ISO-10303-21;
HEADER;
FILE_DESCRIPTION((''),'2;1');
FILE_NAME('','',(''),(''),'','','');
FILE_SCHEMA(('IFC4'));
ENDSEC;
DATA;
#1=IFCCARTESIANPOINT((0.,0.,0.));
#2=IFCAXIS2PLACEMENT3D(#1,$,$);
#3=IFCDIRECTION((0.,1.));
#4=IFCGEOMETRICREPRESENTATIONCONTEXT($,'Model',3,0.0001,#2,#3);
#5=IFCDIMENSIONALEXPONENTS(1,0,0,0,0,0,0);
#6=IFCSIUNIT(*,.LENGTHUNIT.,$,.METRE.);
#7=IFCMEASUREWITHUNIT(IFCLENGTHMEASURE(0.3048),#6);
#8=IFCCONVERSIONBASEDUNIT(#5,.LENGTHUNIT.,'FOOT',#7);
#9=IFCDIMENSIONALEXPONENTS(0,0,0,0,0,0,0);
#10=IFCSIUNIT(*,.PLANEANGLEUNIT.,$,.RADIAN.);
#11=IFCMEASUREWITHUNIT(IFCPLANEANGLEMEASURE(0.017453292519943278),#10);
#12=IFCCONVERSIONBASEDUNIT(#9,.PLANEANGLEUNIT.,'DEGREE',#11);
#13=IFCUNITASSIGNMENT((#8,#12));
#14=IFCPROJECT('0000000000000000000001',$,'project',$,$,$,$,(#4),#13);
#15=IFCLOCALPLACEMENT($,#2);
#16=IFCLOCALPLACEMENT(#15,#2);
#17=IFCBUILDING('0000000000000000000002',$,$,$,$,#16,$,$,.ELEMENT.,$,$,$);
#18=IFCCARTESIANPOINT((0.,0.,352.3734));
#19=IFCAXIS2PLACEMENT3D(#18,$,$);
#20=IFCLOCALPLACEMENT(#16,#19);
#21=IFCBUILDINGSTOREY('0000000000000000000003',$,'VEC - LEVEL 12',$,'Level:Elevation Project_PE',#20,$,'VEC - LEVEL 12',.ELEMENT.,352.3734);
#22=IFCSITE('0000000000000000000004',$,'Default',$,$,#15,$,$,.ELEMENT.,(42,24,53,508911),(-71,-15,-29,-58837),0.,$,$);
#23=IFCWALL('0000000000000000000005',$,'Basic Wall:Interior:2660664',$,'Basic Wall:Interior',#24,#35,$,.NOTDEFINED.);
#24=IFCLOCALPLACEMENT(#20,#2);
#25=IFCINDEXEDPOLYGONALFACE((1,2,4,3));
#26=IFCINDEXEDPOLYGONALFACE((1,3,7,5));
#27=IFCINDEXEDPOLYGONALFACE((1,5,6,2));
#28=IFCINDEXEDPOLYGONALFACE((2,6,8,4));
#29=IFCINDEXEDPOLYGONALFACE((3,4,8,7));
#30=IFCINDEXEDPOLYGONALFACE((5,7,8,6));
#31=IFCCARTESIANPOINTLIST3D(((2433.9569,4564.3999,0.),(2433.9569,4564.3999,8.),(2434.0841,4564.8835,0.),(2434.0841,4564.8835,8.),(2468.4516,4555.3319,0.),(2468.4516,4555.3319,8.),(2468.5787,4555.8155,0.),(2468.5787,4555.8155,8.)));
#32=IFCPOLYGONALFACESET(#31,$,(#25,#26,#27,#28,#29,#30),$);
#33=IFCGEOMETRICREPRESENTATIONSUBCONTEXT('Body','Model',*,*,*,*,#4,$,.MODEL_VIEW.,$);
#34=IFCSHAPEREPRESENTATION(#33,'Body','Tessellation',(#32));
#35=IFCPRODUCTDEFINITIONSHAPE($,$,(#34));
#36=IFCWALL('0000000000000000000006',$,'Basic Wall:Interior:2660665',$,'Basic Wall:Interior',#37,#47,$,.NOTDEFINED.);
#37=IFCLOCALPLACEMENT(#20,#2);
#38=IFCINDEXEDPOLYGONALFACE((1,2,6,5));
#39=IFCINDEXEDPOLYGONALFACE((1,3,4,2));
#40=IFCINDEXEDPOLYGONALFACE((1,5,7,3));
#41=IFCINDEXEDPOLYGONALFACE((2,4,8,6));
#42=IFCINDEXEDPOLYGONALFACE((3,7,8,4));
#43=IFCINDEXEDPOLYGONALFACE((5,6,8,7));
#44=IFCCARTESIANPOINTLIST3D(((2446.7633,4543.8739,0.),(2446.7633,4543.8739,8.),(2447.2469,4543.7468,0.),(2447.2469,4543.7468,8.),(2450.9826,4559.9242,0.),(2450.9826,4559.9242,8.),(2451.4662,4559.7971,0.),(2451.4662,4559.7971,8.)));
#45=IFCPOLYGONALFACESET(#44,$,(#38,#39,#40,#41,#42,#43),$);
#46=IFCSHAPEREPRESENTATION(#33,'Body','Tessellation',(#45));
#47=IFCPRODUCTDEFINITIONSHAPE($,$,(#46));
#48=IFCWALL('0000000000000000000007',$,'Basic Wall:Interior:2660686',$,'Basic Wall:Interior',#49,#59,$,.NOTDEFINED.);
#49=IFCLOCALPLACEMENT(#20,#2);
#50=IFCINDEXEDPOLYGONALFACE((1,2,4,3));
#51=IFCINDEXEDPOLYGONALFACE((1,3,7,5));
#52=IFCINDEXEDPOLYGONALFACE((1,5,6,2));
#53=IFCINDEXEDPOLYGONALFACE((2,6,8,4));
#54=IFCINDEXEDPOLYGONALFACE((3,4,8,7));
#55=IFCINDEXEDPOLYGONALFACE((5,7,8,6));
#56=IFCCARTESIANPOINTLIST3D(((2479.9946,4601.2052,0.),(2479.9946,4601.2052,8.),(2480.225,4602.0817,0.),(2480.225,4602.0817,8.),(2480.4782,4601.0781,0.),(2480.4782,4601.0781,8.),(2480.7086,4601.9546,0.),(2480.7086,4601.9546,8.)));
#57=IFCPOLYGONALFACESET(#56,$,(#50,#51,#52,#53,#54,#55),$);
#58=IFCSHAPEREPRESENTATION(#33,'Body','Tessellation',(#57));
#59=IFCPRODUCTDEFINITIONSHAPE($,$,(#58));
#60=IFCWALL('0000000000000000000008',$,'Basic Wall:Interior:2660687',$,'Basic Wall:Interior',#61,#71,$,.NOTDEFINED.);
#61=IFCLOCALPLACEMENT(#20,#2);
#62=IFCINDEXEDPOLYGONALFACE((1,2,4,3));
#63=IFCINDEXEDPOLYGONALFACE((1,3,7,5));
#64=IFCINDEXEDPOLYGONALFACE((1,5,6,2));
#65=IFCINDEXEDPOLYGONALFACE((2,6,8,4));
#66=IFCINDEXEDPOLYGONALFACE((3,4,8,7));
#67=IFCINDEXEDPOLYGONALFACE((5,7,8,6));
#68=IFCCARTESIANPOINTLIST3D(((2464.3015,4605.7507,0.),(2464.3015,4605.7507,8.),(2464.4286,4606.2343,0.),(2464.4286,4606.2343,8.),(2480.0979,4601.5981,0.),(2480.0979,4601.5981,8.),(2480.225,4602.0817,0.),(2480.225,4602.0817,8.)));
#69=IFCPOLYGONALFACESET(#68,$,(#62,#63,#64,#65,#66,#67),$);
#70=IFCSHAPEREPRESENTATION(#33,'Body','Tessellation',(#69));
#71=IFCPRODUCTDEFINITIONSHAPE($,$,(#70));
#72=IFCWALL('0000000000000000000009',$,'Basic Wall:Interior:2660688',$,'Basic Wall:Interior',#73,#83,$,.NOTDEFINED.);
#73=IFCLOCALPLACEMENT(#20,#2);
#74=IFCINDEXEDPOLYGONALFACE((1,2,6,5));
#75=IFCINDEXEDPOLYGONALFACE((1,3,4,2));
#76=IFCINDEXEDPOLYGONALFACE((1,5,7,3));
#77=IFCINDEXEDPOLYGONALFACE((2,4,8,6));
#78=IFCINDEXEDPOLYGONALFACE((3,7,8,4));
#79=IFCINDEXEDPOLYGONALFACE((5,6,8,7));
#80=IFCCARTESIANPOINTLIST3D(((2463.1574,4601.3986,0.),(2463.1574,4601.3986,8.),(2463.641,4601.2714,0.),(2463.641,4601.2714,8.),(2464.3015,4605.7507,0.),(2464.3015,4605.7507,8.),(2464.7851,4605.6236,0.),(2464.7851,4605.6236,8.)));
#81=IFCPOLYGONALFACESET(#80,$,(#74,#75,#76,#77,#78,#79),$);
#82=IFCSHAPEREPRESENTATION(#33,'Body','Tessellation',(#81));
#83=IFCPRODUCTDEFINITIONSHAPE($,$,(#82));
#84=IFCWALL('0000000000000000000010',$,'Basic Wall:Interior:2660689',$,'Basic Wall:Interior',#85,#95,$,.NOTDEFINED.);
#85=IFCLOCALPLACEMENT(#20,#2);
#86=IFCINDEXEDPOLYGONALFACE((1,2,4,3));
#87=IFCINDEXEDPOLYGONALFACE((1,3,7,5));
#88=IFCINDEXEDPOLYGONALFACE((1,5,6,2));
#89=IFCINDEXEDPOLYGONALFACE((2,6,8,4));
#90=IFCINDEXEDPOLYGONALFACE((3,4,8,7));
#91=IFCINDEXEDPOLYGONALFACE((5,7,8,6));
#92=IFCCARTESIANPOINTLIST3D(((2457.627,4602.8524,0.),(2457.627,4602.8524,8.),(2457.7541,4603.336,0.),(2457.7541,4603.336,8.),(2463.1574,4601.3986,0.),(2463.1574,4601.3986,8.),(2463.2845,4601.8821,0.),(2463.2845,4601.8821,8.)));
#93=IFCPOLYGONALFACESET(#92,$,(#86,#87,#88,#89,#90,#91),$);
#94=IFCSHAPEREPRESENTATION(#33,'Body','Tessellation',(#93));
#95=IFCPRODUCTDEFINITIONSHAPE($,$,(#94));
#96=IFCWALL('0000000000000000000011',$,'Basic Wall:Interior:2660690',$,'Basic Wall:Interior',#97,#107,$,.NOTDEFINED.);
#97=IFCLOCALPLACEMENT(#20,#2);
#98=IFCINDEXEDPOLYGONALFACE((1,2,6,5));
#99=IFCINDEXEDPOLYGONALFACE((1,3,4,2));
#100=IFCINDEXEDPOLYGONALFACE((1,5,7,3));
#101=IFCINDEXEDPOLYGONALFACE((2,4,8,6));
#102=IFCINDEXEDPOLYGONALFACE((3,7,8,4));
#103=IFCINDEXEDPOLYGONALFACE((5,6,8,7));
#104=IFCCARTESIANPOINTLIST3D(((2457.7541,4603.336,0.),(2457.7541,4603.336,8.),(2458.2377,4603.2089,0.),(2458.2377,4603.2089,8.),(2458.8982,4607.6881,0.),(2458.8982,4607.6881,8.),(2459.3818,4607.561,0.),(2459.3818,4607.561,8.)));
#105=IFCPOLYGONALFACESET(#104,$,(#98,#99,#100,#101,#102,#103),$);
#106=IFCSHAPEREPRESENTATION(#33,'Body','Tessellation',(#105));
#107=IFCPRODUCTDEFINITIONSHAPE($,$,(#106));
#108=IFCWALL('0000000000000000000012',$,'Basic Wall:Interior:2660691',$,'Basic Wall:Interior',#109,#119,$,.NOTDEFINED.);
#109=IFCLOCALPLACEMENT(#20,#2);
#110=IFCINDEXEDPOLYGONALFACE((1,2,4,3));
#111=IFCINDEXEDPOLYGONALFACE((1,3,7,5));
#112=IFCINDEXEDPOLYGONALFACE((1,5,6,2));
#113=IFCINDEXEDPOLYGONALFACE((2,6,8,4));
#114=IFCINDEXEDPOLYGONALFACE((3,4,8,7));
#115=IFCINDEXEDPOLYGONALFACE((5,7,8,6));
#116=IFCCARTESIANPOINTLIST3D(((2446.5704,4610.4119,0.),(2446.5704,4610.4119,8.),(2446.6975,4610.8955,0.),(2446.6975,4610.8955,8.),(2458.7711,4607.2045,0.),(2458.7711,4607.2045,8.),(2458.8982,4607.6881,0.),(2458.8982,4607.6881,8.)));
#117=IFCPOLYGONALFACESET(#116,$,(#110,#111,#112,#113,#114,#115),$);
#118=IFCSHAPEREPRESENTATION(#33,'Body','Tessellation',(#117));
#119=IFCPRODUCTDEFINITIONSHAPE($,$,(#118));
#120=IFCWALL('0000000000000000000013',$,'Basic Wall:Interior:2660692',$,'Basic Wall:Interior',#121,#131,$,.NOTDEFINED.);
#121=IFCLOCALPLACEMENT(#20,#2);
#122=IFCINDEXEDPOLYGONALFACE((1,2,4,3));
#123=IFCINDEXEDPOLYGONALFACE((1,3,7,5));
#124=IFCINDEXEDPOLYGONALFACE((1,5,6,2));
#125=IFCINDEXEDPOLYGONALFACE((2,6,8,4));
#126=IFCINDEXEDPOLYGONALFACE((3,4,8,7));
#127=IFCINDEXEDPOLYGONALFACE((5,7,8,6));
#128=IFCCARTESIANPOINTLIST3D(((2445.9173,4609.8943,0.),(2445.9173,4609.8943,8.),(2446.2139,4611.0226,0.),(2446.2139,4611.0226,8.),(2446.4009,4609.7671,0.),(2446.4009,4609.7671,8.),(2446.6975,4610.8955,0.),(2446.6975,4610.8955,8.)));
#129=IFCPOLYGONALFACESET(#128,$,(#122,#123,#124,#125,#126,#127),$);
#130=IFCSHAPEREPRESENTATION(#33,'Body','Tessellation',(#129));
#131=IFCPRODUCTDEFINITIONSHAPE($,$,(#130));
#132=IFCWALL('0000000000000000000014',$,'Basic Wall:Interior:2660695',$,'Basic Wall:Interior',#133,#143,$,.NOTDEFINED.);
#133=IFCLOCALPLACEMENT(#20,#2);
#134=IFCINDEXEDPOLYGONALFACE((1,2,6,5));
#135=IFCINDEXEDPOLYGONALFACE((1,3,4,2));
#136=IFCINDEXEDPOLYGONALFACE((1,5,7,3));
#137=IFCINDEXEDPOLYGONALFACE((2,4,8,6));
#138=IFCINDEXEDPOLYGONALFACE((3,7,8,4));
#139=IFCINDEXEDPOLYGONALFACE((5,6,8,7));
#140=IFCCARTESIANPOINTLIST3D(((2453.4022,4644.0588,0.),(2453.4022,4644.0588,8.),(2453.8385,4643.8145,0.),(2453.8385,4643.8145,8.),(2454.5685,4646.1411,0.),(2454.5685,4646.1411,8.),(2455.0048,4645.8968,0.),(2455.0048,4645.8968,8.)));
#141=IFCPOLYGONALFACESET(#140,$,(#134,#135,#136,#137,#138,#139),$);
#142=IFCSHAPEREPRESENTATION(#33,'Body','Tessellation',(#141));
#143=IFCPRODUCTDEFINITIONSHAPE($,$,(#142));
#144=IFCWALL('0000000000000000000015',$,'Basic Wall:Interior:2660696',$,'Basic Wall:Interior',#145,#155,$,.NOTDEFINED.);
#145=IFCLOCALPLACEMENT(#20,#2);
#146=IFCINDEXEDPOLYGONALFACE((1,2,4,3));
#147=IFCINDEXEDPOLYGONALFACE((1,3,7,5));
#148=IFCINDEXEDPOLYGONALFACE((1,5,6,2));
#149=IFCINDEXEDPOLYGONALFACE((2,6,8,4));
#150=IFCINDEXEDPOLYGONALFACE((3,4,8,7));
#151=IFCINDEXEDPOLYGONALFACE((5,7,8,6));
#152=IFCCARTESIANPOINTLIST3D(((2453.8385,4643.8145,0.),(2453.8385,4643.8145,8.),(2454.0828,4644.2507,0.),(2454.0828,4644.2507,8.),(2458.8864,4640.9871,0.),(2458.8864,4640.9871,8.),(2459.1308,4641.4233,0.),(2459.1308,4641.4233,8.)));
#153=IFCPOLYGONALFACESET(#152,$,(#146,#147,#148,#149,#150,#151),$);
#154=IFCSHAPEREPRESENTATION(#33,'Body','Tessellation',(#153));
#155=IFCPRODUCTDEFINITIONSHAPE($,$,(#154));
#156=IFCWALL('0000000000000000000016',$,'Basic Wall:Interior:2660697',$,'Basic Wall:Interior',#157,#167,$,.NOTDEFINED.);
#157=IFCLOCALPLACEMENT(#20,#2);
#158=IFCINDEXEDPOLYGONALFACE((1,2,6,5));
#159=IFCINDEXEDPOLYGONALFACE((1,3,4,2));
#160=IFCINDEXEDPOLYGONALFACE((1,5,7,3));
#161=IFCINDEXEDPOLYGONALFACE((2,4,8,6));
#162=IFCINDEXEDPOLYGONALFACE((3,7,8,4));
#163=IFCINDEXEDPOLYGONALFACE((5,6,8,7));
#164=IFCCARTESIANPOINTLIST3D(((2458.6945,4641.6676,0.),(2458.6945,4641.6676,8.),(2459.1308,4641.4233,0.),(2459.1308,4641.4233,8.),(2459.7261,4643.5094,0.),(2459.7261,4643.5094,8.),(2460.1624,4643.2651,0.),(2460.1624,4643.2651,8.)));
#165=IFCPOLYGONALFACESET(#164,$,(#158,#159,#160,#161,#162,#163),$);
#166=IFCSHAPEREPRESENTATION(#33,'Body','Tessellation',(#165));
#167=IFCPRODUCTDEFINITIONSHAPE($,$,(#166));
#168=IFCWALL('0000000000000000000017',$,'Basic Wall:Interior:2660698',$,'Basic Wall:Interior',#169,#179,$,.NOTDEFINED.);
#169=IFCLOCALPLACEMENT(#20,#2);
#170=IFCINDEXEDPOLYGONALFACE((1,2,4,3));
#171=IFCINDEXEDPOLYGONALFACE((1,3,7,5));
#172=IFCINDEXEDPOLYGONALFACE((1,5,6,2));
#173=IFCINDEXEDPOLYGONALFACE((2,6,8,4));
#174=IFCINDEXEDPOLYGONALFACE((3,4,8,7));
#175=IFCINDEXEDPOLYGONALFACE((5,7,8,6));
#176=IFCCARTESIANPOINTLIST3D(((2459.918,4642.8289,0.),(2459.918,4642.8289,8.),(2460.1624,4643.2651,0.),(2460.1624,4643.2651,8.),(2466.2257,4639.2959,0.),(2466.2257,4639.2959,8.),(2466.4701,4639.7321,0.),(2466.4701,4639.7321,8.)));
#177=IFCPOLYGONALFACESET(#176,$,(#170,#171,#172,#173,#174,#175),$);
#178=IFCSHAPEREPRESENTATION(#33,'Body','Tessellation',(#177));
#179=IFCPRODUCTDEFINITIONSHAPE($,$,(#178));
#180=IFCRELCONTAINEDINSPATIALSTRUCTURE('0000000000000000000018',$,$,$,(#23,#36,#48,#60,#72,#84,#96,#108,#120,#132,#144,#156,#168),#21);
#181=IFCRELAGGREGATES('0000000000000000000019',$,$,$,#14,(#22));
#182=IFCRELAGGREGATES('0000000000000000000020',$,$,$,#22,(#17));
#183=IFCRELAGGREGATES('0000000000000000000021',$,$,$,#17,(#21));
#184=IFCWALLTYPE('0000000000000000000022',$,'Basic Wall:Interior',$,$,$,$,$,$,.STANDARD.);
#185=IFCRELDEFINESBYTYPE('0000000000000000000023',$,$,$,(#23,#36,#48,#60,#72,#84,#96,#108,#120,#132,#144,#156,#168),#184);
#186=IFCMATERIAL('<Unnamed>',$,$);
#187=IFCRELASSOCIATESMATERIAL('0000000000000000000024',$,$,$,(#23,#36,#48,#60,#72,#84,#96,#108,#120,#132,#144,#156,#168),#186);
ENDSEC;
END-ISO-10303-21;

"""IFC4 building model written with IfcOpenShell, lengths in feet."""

from ifc_helpers import new_model, entity, si_unit, converted_unit, direction, frame, origin, place, context, subcontext, project, spatial, indexed_curve, outline, extrude, material, type_object, element, save


model = new_model("IFC4")

# Units and contexts
model_context = context("Model", 3, precision=0.0001, world=origin(), true_north=direction((0.0, 1.0)))
body_context = subcontext(model_context, "Body", "Model", "MODEL_VIEW")
ifc_project = project(units=[converted_unit("LENGTHUNIT", "FOOT", entity("IfcLengthMeasure", 0.3048), si_unit("LENGTHUNIT", "METRE"), dimensions=[1, 0, 0, 0, 0, 0, 0]), converted_unit("PLANEANGLEUNIT", "DEGREE", entity("IfcPlaneAngleMeasure", 0.017453292519943278), si_unit("PLANEANGLEUNIT", "RADIAN"), dimensions=[0, 0, 0, 0, 0, 0, 0])], contexts=[model_context])

# Site, building, storey
site_placement = place(None, origin())
site = spatial("IfcSite", under=ifc_project, at=site_placement, Name="Default", CompositionType="ELEMENT", RefLatitude=(42, 24, 53, 508911), RefLongitude=(-71, -15, -29, -58837), RefElevation=0.0)
building_placement = place(site_placement, origin())
building = spatial("IfcBuilding", under=site, at=building_placement, CompositionType="ELEMENT")
storey_placement = place(building_placement, frame((0.0, 0.0, 352.3734)))
storey = spatial("IfcBuildingStorey", under=building, at=storey_placement, Name="VEC - LEVEL 12", ObjectType="Level:Elevation Project_PE", LongName="VEC - LEVEL 12", CompositionType="ELEMENT", Elevation=352.3734)

# Walls
ifc_material_1 = material(Name="<Unnamed>")
wall_type = type_object("IfcWallType", Name="Basic Wall:Interior", PredefinedType="STANDARD")
wall_1_placement = place(storey_placement, frame((2434.0205, 4564.6417, 0.0), z_axis=(0.0, 0.0, 1.0), x_axis=(0.96714, -0.254244, 0.0)))
element("IfcWall", 1, at=wall_1_placement, inside=storey, type_object=wall_type, material=ifc_material_1, Name="Basic Wall:Interior:2660664", ObjectType="Basic Wall:Interior", PredefinedType="NOTDEFINED", context=body_context, shape_type="SweptSolid", body=[
    extrude(outline(indexed_curve([(35.6667, 0.25), (0.0, 0.25), (0.0, -0.25), (35.6667, -0.25), (35.6667, 0.25)], self_intersect=False)), origin(), (0.0, 0.0, 1.0), 8.0),
])
wall_2_placement = place(storey_placement, frame((2451.2244, 4559.8606, 0.0), z_axis=(0.0, 0.0, 1.0), x_axis=(-0.254244, -0.96714, 0.0)))
element("IfcWall", 2, at=wall_2_placement, inside=storey, type_object=wall_type, material=ifc_material_1, Name="Basic Wall:Interior:2660665", ObjectType="Basic Wall:Interior", PredefinedType="NOTDEFINED", context=body_context, shape_type="SweptSolid", body=[
    extrude(outline(indexed_curve([(16.5956, 0.25), (0.0, 0.25), (0.0, -0.25), (16.5956, -0.25), (16.5956, 0.25)], self_intersect=False)), origin(), (0.0, 0.0, 1.0), 8.0),
])
wall_3_placement = place(storey_placement, frame((2480.2364, 4601.1416, 0.0), z_axis=(0.0, 0.0, 1.0), x_axis=(0.254244, 0.96714, 0.0)))
element("IfcWall", 3, at=wall_3_placement, inside=storey, type_object=wall_type, material=ifc_material_1, Name="Basic Wall:Interior:2660686", ObjectType="Basic Wall:Interior", PredefinedType="NOTDEFINED", context=body_context, shape_type="SweptSolid", body=[
    extrude(outline(indexed_curve([(0.9062, 0.25), (0.0, 0.25), (0.0, -0.25), (0.9062, -0.25), (0.9062, 0.25)], self_intersect=False)), origin(), (0.0, 0.0, 1.0), 8.0),
])
wall_4_placement = place(storey_placement, frame((2480.1615, 4601.8399, 0.0), z_axis=(0.0, 0.0, 1.0), x_axis=(-0.96714, 0.254244, 0.0)))
element("IfcWall", 4, at=wall_4_placement, inside=storey, type_object=wall_type, material=ifc_material_1, Name="Basic Wall:Interior:2660687", ObjectType="Basic Wall:Interior", PredefinedType="NOTDEFINED", context=body_context, shape_type="SweptSolid", body=[
    extrude(outline(indexed_curve([(16.3331, 0.25), (0.0, 0.25), (0.0, -0.25), (16.3331, -0.25), (16.3331, 0.25)], self_intersect=False)), origin(), (0.0, 0.0, 1.0), 8.0),
])
wall_5_placement = place(storey_placement, frame((2464.5433, 4605.6871, 0.0), z_axis=(0.0, 0.0, 1.0), x_axis=(-0.254244, -0.96714, 0.0)))
element("IfcWall", 5, at=wall_5_placement, inside=storey, type_object=wall_type, material=ifc_material_1, Name="Basic Wall:Interior:2660688", ObjectType="Basic Wall:Interior", PredefinedType="NOTDEFINED", context=body_context, shape_type="SweptSolid", body=[
    extrude(outline(indexed_curve([(4.5, 0.25), (0.0, 0.25), (0.0, -0.25), (4.5, -0.25), (4.5, 0.25)], self_intersect=False)), origin(), (0.0, 0.0, 1.0), 8.0),
])
wall_6_placement = place(storey_placement, frame((2463.221, 4601.6404, 0.0), z_axis=(0.0, 0.0, 1.0), x_axis=(-0.96714, 0.254244, 0.0)))
element("IfcWall", 6, at=wall_6_placement, inside=storey, type_object=wall_type, material=ifc_material_1, Name="Basic Wall:Interior:2660689", ObjectType="Basic Wall:Interior", PredefinedType="NOTDEFINED", context=body_context, shape_type="SweptSolid", body=[
    extrude(outline(indexed_curve([(5.7183, 0.25), (0.0, 0.25), (0.0, -0.25), (5.7183, -0.25), (5.7183, 0.25)], self_intersect=False)), origin(), (0.0, 0.0, 1.0), 8.0),
])
wall_7_placement = place(storey_placement, frame((2457.9959, 4603.2724, 0.0), z_axis=(0.0, 0.0, 1.0), x_axis=(0.254244, 0.96714, 0.0)))
element("IfcWall", 7, at=wall_7_placement, inside=storey, type_object=wall_type, material=ifc_material_1, Name="Basic Wall:Interior:2660690", ObjectType="Basic Wall:Interior", PredefinedType="NOTDEFINED", context=body_context, shape_type="SweptSolid", body=[
    extrude(outline(indexed_curve([(4.5, 0.25), (0.0, 0.25), (0.0, -0.25), (4.5, -0.25), (4.5, 0.25)], self_intersect=False)), origin(), (0.0, 0.0, 1.0), 8.0),
])
wall_8_placement = place(storey_placement, frame((2458.8347, 4607.4463, 0.0), z_axis=(0.0, 0.0, 1.0), x_axis=(-0.96714, 0.254244, 0.0)))
element("IfcWall", 8, at=wall_8_placement, inside=storey, type_object=wall_type, material=ifc_material_1, Name="Basic Wall:Interior:2660691", ObjectType="Basic Wall:Interior", PredefinedType="NOTDEFINED", context=body_context, shape_type="SweptSolid", body=[
    extrude(outline(indexed_curve([(12.6153, 0.25), (0.0, 0.25), (0.0, -0.25), (12.6153, -0.25), (12.6153, 0.25)], self_intersect=False)), origin(), (0.0, 0.0, 1.0), 8.0),
])
wall_9_placement = place(storey_placement, frame((2446.4557, 4610.959, 0.0), z_axis=(0.0, 0.0, 1.0), x_axis=(-0.254244, -0.96714, 0.0)))
element("IfcWall", 9, at=wall_9_placement, inside=storey, type_object=wall_type, material=ifc_material_1, Name="Basic Wall:Interior:2660692", ObjectType="Basic Wall:Interior", PredefinedType="NOTDEFINED", context=body_context, shape_type="SweptSolid", body=[
    extrude(outline(indexed_curve([(1.1667, 0.25), (0.0, 0.25), (0.0, -0.25), (1.1667, -0.25), (1.1667, 0.25)], self_intersect=False)), origin(), (0.0, 0.0, 1.0), 8.0),
])
wall_10_placement = place(storey_placement, frame((2454.7866, 4646.0189, 0.0), z_axis=(0.0, 0.0, 1.0), x_axis=(-0.488675, -0.872466, 0.0)))
element("IfcWall", 10, at=wall_10_placement, inside=storey, type_object=wall_type, material=ifc_material_1, Name="Basic Wall:Interior:2660695", ObjectType="Basic Wall:Interior", PredefinedType="NOTDEFINED", context=body_context, shape_type="SweptSolid", body=[
    extrude(outline(indexed_curve([(2.3867, 0.25), (0.0, 0.25), (0.0, -0.25), (2.3867, -0.25), (2.3867, 0.25)], self_intersect=False)), origin(), (0.0, 0.0, 1.0), 8.0),
])
wall_11_placement = place(storey_placement, frame((2453.9606, 4644.0326, 0.0), z_axis=(0.0, 0.0, 1.0), x_axis=(0.872466, -0.488675, 0.0)))
element("IfcWall", 11, at=wall_11_placement, inside=storey, type_object=wall_type, material=ifc_material_1, Name="Basic Wall:Interior:2660696", ObjectType="Basic Wall:Interior", PredefinedType="NOTDEFINED", context=body_context, shape_type="SweptSolid", body=[
    extrude(outline(indexed_curve([(5.7859, 0.25), (0.0, 0.25), (0.0, -0.25), (5.7859, -0.25), (5.7859, 0.25)], self_intersect=False)), origin(), (0.0, 0.0, 1.0), 8.0),
])
wall_12_placement = place(storey_placement, frame((2458.9126, 4641.5455, 0.0), z_axis=(0.0, 0.0, 1.0), x_axis=(0.488675, 0.872466, 0.0)))
element("IfcWall", 12, at=wall_12_placement, inside=storey, type_object=wall_type, material=ifc_material_1, Name="Basic Wall:Interior:2660697", ObjectType="Basic Wall:Interior", PredefinedType="NOTDEFINED", context=body_context, shape_type="SweptSolid", body=[
    extrude(outline(indexed_curve([(2.111, 0.25), (0.0, 0.25), (0.0, -0.25), (2.111, -0.25), (2.111, 0.25)], self_intersect=False)), origin(), (0.0, 0.0, 1.0), 8.0),
])
wall_13_placement = place(storey_placement, frame((2460.0402, 4643.047, 0.0), z_axis=(0.0, 0.0, 1.0), x_axis=(0.872466, -0.488675, 0.0)))
element("IfcWall", 13, at=wall_13_placement, inside=storey, type_object=wall_type, material=ifc_material_1, Name="Basic Wall:Interior:2660698", ObjectType="Basic Wall:Interior", PredefinedType="NOTDEFINED", context=body_context, shape_type="SweptSolid", body=[
    extrude(outline(indexed_curve([(7.2297, 0.25), (0.0, 0.25), (0.0, -0.25), (7.2297, -0.25), (7.2297, 0.25)], self_intersect=False)), origin(), (0.0, 0.0, 1.0), 8.0),
])

save(model, "model.ifc")
